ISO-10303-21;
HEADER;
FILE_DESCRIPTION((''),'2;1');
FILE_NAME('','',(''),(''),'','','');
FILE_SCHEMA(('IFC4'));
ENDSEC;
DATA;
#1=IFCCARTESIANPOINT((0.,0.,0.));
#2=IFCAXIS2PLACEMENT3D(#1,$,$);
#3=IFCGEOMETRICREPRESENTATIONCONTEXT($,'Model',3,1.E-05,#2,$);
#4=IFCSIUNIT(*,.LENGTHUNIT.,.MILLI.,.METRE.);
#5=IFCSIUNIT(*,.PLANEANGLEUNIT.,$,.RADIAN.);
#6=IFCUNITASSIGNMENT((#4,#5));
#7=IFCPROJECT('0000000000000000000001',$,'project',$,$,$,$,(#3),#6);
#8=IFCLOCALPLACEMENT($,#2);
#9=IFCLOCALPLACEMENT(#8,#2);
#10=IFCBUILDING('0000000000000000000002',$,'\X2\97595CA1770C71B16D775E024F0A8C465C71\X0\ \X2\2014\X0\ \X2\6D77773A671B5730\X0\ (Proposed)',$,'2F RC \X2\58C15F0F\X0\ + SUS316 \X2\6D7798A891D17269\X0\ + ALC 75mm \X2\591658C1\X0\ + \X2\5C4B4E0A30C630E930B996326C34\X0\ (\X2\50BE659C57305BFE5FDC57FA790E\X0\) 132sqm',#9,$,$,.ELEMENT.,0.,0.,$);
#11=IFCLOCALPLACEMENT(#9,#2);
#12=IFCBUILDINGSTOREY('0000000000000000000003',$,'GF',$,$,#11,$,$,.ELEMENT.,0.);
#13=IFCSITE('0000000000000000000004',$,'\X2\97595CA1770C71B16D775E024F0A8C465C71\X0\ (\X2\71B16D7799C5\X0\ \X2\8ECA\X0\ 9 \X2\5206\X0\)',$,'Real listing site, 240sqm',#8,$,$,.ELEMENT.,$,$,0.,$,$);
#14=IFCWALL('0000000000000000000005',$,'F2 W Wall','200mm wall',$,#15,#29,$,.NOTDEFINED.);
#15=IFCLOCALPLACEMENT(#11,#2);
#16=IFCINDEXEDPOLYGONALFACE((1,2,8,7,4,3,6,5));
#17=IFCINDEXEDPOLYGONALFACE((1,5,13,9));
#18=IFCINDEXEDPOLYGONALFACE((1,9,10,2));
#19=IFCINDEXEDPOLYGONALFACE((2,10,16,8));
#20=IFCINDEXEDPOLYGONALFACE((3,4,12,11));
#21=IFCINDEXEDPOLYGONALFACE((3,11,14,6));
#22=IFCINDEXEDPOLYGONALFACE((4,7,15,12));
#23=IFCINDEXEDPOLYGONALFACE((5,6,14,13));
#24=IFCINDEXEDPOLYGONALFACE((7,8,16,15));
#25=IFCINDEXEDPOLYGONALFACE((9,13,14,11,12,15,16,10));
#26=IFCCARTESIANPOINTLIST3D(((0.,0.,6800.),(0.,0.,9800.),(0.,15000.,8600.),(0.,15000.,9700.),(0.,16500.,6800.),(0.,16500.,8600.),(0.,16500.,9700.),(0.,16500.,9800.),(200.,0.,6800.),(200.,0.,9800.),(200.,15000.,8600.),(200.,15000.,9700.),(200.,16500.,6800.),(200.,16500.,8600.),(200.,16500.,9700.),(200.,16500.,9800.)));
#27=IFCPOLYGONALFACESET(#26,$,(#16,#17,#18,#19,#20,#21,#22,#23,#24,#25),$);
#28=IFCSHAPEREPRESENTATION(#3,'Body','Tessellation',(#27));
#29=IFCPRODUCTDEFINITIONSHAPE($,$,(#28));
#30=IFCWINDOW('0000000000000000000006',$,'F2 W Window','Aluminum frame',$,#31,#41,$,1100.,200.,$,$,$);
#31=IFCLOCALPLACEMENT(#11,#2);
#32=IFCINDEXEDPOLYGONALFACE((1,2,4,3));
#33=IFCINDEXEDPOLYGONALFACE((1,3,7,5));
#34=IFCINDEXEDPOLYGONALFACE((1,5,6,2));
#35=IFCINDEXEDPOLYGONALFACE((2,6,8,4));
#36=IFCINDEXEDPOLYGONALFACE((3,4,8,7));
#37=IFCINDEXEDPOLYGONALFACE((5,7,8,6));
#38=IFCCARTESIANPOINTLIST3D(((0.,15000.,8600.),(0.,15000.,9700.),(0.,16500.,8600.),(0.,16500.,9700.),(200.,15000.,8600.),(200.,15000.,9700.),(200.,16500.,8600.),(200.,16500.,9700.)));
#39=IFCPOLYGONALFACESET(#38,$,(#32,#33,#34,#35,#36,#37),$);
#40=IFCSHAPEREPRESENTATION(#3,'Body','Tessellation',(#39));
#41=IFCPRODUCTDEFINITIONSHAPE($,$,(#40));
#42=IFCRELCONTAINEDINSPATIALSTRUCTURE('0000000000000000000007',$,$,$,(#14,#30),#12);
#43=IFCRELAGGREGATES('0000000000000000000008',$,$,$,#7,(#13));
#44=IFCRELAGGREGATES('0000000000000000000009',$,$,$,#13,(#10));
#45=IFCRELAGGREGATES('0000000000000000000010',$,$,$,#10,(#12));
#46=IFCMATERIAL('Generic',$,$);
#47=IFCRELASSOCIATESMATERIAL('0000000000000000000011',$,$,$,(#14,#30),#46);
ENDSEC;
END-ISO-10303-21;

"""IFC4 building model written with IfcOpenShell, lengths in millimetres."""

from ifc_helpers import new_model, si_unit, frame, frame_2d, origin, place, context, project, spatial, rectangle, extrude, material, element, fill, save


model = new_model("IFC4")

# Units and contexts
model_context = context("Model", 3, precision=1e-05, world=origin())
ifc_project = project(units=[si_unit("LENGTHUNIT", "METRE", prefix="MILLI"), si_unit("PLANEANGLEUNIT", "RADIAN")], contexts=[model_context])

# Site, building, storey
site_placement = place(None, origin())
site = spatial("IfcSite", under=ifc_project, at=site_placement, Name="静岡県熱海市伊豆山 (熱海駅 車 9 分)", ObjectType="Real listing site, 240sqm", CompositionType="ELEMENT", RefElevation=0.0)
building_placement = place(site_placement, origin())
building = spatial("IfcBuilding", under=site, at=building_placement, Name="静岡県熱海市伊豆山 — 海眺望地 (Proposed)", ObjectType="2F RC 壁式 + SUS316 海風金物 + ALC 75mm 外壁 + 屋上テラス防水 (傾斜地対応基礎) 132sqm", CompositionType="ELEMENT", ElevationOfRefHeight=0.0, ElevationOfTerrain=0.0)
storey_placement = place(building_placement, origin())
storey = spatial("IfcBuildingStorey", under=building, at=storey_placement, Name="GF", CompositionType="ELEMENT", Elevation=0.0)

# Shared definitions
ifc_material_1 = material(Name="Generic")

# Wall, opening, window
wall_1_placement = place(storey_placement, frame((0.0, 0.0, 3400.0)))
wall_1 = element("IfcWall", 1, at=wall_1_placement, inside=storey, material=ifc_material_1, Name="F2 W Wall", Description="200mm wall", PredefinedType="NOTDEFINED", context=model_context, shape_type="SweptSolid", body=[
    extrude(rectangle(XDim=200.0, YDim=16500.0, at=frame_2d((100.0, 8250.0))), frame((0.0, 0.0, 3400.0)), (0.0, 0.0, 1.0), 3000.0),
])
opening_1_placement = place(storey_placement, frame((0.0, 7500.0, 4300.0)))
opening_1 = element("IfcOpeningElement", 2, at=opening_1_placement, cuts=wall_1, PredefinedType="NOTDEFINED", context=model_context, shape_type="SweptSolid", body=[
    extrude(rectangle(XDim=200.0, YDim=1500.0, at=frame_2d((100.0, 750.0))), frame((0.0, 7500.0, 4300.0)), (0.0, 0.0, 1.0), 1100.0),
])
window_1_placement = place(storey_placement, frame((0.0, 7500.0, 4300.0)))
window_1 = element("IfcWindow", 3, at=window_1_placement, inside=storey, material=ifc_material_1, Name="F2 W Window", Description="Aluminum frame", OverallHeight=1100.0, OverallWidth=200.0, context=model_context, shape_type="SweptSolid", body=[
    extrude(rectangle(XDim=200.0, YDim=1500.0, at=frame_2d((100.0, 750.0))), frame((0.0, 7500.0, 4300.0)), (0.0, 0.0, 1.0), 1100.0),
])
fill(opening_1, window_1)

save(model, "model.ifc")
